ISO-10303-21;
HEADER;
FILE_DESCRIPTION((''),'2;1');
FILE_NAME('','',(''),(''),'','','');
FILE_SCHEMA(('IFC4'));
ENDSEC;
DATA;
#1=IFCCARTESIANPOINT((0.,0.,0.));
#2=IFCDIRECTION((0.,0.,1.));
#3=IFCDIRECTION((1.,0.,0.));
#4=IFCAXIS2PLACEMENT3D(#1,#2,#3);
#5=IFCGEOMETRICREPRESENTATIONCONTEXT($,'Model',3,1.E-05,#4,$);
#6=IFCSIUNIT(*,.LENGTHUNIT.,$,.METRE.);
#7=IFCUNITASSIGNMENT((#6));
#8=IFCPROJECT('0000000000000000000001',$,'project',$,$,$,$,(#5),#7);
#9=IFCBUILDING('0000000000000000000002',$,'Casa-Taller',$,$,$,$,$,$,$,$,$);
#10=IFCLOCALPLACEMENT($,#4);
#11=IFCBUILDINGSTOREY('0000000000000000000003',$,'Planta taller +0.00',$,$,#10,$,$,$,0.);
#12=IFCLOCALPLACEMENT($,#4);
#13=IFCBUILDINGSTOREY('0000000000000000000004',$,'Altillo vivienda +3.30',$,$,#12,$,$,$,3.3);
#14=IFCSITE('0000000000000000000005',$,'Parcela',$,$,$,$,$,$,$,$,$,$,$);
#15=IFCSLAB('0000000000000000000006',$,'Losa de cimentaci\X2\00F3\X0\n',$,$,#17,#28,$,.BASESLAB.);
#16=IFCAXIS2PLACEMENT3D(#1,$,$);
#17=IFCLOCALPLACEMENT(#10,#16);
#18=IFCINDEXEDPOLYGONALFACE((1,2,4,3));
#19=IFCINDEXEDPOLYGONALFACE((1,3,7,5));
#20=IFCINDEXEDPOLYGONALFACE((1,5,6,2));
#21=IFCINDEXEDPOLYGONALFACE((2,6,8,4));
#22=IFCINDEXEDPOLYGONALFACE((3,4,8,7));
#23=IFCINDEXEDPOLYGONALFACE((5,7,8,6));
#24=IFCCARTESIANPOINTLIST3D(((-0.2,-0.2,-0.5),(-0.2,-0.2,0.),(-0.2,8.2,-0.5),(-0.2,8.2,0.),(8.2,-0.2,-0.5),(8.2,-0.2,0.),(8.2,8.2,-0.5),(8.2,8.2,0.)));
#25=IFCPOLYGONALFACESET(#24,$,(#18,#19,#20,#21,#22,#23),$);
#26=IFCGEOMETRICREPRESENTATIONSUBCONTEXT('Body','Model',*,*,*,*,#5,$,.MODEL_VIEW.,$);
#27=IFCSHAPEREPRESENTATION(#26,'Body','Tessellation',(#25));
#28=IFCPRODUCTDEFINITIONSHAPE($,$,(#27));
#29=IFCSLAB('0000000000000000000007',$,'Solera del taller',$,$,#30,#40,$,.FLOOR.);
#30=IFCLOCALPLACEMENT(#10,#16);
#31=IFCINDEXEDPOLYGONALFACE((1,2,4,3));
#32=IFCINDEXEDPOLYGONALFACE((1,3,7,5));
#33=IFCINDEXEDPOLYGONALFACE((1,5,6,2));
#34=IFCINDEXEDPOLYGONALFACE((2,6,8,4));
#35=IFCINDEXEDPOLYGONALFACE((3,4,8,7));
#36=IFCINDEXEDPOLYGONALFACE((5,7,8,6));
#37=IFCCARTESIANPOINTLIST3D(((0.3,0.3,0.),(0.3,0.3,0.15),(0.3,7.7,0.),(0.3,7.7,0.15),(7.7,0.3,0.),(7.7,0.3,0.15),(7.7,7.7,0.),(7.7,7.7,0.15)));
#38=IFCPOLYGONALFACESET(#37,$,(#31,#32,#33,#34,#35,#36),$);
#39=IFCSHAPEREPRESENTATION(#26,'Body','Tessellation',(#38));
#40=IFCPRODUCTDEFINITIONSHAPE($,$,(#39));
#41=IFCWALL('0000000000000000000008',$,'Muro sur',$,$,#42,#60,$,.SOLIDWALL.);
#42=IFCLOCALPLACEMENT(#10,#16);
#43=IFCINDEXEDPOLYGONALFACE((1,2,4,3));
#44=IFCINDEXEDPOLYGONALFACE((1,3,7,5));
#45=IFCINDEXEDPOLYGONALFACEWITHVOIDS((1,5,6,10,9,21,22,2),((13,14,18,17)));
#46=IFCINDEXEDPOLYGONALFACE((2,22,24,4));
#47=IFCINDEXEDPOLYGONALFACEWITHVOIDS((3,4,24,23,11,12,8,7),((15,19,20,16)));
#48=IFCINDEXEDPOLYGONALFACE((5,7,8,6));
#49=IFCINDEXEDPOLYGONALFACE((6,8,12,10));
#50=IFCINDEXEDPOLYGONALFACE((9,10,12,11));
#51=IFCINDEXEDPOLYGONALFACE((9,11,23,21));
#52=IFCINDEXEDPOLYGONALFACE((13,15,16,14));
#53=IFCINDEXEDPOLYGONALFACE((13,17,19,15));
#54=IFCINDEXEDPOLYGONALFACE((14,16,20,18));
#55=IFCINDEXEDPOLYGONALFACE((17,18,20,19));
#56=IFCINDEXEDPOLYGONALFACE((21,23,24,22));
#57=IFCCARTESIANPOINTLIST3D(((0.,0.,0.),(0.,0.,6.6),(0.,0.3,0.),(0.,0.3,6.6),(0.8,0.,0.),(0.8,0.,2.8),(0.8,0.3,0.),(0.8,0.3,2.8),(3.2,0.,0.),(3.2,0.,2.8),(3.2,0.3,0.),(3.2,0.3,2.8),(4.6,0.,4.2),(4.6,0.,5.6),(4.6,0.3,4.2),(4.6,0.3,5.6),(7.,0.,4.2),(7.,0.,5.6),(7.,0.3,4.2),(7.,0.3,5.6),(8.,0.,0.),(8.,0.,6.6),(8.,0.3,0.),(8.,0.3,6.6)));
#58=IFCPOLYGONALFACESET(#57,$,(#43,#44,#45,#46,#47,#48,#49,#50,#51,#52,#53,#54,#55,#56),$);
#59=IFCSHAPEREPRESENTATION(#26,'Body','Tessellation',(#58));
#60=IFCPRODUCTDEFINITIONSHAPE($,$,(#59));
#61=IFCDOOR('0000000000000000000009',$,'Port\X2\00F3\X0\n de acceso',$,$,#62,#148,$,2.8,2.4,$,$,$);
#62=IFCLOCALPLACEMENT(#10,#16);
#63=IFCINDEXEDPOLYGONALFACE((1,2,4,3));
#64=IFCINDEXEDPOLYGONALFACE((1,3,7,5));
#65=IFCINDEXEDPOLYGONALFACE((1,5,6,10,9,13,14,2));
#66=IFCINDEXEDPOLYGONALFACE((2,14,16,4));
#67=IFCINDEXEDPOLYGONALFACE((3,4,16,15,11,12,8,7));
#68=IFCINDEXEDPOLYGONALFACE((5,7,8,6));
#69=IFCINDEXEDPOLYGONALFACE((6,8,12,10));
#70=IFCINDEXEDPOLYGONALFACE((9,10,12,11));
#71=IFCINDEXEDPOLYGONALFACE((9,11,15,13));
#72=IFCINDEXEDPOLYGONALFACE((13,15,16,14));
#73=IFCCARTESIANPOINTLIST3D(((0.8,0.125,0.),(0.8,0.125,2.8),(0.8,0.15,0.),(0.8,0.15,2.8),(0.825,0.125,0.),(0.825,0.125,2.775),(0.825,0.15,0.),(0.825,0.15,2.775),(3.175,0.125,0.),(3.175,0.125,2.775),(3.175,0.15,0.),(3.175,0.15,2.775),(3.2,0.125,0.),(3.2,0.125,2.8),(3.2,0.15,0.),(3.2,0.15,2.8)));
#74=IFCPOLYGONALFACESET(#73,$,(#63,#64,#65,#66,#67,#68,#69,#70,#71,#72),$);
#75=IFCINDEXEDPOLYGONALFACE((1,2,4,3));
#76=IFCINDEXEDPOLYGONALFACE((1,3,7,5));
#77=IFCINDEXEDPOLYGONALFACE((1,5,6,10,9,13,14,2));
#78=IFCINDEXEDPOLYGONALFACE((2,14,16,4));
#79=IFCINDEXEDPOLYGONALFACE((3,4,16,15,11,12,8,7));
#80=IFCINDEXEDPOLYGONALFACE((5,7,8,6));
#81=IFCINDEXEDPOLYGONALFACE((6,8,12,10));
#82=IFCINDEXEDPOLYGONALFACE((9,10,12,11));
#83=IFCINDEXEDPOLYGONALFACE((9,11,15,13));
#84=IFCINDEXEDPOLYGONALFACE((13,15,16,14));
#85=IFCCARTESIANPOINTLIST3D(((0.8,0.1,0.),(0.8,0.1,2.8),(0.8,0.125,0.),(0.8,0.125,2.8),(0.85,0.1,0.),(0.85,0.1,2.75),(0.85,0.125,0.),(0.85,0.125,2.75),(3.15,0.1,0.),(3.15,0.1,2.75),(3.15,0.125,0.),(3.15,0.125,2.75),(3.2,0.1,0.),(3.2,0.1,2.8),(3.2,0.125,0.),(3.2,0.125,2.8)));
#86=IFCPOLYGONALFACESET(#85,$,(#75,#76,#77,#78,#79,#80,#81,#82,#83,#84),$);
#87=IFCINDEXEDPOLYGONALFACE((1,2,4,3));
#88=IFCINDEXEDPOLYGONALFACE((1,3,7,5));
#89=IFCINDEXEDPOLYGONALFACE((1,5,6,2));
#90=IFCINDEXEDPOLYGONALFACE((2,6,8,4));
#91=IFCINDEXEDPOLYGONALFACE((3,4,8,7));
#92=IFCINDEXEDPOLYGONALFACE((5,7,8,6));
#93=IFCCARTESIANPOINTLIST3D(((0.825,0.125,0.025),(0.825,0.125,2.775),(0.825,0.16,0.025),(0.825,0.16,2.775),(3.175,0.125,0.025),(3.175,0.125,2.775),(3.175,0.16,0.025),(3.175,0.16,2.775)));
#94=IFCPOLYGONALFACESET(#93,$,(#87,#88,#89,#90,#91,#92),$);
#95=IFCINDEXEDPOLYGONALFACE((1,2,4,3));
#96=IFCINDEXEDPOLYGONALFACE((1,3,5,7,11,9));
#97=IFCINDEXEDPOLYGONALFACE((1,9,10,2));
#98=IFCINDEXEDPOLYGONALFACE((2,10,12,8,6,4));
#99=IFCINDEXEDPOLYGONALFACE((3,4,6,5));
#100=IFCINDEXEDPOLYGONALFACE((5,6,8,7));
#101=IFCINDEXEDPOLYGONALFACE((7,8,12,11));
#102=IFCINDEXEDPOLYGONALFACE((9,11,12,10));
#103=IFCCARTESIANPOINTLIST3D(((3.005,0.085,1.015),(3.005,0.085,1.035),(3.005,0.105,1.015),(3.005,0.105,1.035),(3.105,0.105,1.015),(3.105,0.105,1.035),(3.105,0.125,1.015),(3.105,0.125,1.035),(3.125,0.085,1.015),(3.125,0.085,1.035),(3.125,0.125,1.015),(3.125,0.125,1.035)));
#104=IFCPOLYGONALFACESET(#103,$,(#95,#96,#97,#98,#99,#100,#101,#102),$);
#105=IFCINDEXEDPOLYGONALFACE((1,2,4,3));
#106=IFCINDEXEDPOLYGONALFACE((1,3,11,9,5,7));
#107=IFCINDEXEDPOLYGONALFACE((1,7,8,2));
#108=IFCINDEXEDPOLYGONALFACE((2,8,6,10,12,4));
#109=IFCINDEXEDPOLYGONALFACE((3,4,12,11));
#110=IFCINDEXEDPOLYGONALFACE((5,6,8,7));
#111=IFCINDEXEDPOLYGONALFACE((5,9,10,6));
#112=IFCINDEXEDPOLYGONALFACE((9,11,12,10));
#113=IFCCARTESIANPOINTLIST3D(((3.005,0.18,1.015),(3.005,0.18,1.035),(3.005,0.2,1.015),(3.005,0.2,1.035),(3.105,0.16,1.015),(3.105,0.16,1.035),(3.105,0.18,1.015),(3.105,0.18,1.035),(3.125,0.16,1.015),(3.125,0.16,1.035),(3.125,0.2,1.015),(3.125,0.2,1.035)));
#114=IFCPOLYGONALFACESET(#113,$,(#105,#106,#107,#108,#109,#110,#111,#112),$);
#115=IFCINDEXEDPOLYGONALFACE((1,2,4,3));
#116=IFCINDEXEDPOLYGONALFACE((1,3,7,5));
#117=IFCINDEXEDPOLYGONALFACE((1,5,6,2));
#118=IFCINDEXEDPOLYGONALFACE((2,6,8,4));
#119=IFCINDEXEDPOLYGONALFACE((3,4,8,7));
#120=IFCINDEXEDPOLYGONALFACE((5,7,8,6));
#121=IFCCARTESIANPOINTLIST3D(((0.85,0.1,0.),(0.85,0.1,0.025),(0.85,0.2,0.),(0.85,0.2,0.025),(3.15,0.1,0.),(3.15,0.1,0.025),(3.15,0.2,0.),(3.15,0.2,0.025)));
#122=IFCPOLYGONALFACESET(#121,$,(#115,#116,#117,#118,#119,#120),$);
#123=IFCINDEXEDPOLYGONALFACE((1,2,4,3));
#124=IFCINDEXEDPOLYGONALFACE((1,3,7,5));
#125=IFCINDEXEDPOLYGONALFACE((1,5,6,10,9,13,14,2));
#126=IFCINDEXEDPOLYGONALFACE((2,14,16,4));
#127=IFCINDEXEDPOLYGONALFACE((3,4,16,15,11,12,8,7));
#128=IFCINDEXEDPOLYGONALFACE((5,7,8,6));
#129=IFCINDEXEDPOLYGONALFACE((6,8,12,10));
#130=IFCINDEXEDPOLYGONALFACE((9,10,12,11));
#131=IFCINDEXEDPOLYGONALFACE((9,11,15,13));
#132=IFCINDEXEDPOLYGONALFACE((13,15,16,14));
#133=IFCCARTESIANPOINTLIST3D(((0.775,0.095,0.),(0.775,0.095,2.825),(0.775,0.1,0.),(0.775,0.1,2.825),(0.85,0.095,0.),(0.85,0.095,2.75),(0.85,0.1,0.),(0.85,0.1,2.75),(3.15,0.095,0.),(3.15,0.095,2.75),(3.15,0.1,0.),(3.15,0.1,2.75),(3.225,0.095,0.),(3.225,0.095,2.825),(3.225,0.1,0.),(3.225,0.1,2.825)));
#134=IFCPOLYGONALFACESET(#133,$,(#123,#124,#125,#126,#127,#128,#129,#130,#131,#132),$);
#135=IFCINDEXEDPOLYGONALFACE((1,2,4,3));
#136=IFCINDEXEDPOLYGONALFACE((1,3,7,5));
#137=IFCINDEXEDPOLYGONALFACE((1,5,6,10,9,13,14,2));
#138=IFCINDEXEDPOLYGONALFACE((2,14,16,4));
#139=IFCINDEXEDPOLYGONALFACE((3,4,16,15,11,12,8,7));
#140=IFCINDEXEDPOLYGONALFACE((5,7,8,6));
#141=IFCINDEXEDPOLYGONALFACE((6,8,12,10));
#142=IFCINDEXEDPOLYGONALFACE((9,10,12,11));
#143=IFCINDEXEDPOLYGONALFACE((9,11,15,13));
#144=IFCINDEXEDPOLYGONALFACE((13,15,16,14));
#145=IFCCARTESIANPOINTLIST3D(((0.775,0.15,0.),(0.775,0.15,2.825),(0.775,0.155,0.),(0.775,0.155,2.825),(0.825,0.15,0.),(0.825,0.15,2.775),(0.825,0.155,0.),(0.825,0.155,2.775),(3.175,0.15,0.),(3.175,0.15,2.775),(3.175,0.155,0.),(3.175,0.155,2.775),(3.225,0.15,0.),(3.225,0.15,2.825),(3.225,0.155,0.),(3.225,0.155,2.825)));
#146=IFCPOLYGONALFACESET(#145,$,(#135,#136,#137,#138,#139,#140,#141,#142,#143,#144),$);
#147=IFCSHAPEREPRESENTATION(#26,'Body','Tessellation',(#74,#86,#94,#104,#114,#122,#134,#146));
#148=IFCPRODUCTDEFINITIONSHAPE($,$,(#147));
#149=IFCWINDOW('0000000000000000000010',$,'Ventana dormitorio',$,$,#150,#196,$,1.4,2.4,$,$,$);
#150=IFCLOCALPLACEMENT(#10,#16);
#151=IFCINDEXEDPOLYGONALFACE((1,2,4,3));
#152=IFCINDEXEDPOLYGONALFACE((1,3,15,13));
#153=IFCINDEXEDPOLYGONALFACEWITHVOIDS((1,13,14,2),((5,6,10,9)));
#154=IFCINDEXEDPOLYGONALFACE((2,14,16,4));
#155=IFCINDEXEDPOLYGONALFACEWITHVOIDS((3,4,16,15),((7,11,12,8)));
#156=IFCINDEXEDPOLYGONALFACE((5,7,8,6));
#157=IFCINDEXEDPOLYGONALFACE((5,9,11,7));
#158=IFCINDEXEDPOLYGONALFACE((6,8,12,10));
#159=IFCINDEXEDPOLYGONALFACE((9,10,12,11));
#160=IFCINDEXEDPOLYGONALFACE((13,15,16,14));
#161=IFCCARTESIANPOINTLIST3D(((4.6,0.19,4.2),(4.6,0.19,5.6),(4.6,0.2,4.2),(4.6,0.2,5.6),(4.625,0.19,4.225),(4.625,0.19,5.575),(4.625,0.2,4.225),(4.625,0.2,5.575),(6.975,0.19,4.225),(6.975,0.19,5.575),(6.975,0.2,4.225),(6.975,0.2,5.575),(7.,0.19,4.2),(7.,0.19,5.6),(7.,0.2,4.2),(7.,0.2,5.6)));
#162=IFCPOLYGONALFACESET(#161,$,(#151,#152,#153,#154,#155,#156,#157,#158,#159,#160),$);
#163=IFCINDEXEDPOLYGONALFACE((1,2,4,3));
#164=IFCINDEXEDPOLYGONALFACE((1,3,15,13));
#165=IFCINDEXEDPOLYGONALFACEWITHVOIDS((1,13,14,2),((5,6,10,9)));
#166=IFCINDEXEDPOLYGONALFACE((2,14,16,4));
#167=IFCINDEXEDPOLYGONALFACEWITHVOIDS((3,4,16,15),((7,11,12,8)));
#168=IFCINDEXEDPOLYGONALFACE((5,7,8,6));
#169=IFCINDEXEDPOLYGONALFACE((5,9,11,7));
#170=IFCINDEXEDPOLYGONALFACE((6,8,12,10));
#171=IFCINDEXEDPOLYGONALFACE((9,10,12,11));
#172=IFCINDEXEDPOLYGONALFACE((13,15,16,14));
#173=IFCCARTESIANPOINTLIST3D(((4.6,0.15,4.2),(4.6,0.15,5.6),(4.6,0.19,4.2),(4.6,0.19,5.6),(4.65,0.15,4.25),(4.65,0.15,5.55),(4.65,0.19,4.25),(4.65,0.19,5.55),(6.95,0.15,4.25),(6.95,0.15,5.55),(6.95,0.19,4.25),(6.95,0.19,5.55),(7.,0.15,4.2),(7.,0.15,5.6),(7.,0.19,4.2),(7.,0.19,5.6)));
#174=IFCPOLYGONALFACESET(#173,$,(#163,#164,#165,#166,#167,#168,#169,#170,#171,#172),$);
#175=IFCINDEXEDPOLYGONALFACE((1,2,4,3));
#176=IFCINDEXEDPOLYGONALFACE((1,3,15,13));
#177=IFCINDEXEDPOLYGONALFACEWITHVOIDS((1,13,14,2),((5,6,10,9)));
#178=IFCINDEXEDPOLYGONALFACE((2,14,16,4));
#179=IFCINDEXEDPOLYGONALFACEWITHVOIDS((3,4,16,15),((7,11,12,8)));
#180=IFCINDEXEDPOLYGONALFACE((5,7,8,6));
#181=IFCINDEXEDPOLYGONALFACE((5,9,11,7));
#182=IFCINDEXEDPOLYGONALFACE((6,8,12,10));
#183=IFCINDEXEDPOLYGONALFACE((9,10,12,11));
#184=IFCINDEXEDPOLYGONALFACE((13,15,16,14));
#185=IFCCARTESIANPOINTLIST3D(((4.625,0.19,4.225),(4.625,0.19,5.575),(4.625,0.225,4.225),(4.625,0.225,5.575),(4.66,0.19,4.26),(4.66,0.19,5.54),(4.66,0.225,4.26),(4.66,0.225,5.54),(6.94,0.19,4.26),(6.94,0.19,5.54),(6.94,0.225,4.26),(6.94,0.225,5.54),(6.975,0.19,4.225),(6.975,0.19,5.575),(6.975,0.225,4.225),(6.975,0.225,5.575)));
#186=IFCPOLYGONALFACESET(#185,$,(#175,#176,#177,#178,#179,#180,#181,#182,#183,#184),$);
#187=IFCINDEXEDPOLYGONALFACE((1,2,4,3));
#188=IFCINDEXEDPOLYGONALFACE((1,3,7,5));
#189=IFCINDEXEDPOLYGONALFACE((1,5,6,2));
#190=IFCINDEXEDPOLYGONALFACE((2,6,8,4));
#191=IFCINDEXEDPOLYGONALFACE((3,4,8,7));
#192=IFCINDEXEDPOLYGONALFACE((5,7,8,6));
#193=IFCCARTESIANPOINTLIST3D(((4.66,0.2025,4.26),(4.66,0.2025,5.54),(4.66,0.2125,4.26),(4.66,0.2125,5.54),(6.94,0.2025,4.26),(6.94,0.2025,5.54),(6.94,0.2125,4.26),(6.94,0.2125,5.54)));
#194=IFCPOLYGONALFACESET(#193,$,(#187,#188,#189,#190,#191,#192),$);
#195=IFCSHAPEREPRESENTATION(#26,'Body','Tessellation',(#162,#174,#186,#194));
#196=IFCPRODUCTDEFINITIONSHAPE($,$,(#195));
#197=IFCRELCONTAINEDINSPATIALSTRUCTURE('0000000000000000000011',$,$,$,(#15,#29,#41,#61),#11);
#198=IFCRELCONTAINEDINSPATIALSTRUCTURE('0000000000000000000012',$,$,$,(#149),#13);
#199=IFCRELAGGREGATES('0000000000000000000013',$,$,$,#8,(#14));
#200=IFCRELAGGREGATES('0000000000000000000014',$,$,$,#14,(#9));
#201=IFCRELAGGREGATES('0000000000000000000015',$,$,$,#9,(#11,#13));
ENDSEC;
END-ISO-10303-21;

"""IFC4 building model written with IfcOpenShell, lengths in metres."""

from ifc_helpers import new_model, si_unit, frame, origin_with_axes, place, context, subcontext, project, spatial, line, indexed_curve, outline, extrude, element, fill, save


model = new_model("IFC4")

# Units and contexts
model_context = context("Model", 3, precision=1e-05, world=origin_with_axes())
body_context = subcontext(model_context, "Body", "Model", "MODEL_VIEW")
ifc_project = project(units=[si_unit("LENGTHUNIT", "METRE")], contexts=[model_context])

# Site, building, storey
site = spatial("IfcSite", under=ifc_project, Name="Parcela")
building = spatial("IfcBuilding", under=site, Name="Casa-Taller")
storey_1_placement = place(None, origin_with_axes())
storey_1 = spatial("IfcBuildingStorey", under=building, at=storey_1_placement, Name="Planta taller +0.00", Elevation=0.0)

# Slabs
slab_1_placement = place(storey_1_placement, frame((-0.2, -0.2, -0.5), z_axis=(0.0, 0.0, 1.0), x_axis=(1.0, 0.0, 0.0)))
element("IfcSlab", 1, at=slab_1_placement, inside=storey_1, Name="Losa de cimentación", PredefinedType="BASESLAB", context=body_context, shape_type="SweptSolid", body=[
    extrude(outline(indexed_curve([(0.0, 0.0), (8.4, 0.0), (8.4, 8.4), (0.0, 8.4)])), None, (0.0, 0.0, 1.0), 0.5),
])
slab_2_placement = place(storey_1_placement, frame((0.3, 0.3, 0.0), z_axis=(0.0, 0.0, 1.0), x_axis=(1.0, 0.0, 0.0)))
element("IfcSlab", 2, at=slab_2_placement, inside=storey_1, Name="Solera del taller", PredefinedType="FLOOR", context=body_context, shape_type="SweptSolid", body=[
    extrude(outline(indexed_curve([(0.0, 0.0), (7.4, 0.0), (7.4, 7.4), (0.0, 7.4)])), None, (0.0, 0.0, 1.0), 0.15),
])

# Wall, openings, door
wall_1_placement = place(storey_1_placement, origin_with_axes())
wall_1 = element("IfcWall", 3, at=wall_1_placement, inside=storey_1, Name="Muro sur", PredefinedType="SOLIDWALL", context=body_context, shape_type="SweptSolid", body=[
    extrude(outline(indexed_curve([(0.0, 0.0), (0.0, 0.3), (8.0, 0.3), (8.0, 0.0), (0.0, 0.0)], self_intersect=False)), origin_with_axes(), (0.0, 0.0, 1.0), 6.6),
])
opening_1_placement = place(wall_1_placement, frame((0.8, -0.1, 0.0), z_axis=(0.0, 0.0, 1.0), x_axis=(1.0, 0.0, 0.0)))
opening_1 = element("IfcOpeningElement", 4, at=opening_1_placement, cuts=wall_1, context=body_context, shape_type="SweptSolid", body=[
    extrude(outline(indexed_curve([(0.0, 0.0), (0.0, 0.5), (2.4, 0.5), (2.4, 0.0), (0.0, 0.0)], self_intersect=False)), origin_with_axes(), (0.0, 0.0, 1.0), 2.8),
])
opening_2_placement = place(wall_1_placement, frame((4.6, -0.1, 4.2), z_axis=(0.0, 0.0, 1.0), x_axis=(1.0, 0.0, 0.0)))
opening_2 = element("IfcOpeningElement", 5, at=opening_2_placement, cuts=wall_1, context=body_context, shape_type="SweptSolid", body=[
    extrude(outline(indexed_curve([(0.0, 0.0), (0.0, 0.5), (2.4, 0.5), (2.4, 0.0), (0.0, 0.0)], self_intersect=False)), origin_with_axes(), (0.0, 0.0, 1.0), 1.4),
])
door_placement = place(opening_1_placement, frame((0.0, 0.2, 0.0), z_axis=(0.0, 0.0, 1.0), x_axis=(1.0, 0.0, 0.0)))
door = element("IfcDoor", 6, at=door_placement, inside=storey_1, Name="Portón de acceso", OverallHeight=2.8, OverallWidth=2.4, context=body_context, shape_type="SweptSolid", body=[
    extrude(outline(indexed_curve([(0.0, 0.0), (0.0, 2.8), (2.4, 2.8), (2.4, 0.0), (2.375, 0.0), (2.375, 2.775), (0.025, 2.775), (0.025, 0.0)], segments=[line(1, 2, 3, 4, 5, 6, 7, 8, 1)])), frame((0.0, 0.025, 0.0), z_axis=(0.0, -1.0, 0.0), x_axis=(1.0, 0.0, 0.0)), (0.0, 0.0, -1.0), 0.025),
    extrude(outline(indexed_curve([(0.0, 0.0), (0.0, 2.8), (2.4, 2.8), (2.4, 0.0), (2.35, 0.0), (2.35, 2.75), (0.05, 2.75), (0.05, 0.0)], segments=[line(1, 2, 3, 4, 5, 6, 7, 8, 1)])), frame((0.0, 0.0, 0.0), z_axis=(0.0, -1.0, 0.0), x_axis=(1.0, 0.0, 0.0)), (0.0, 0.0, -1.0), 0.025),
    extrude(outline(indexed_curve([(0.0, 0.0), (2.35, 0.0), (2.35, 0.035), (0.0, 0.035)], segments=[line(1, 2, 3, 4, 1)])), frame((0.025, 0.025, 0.025), z_axis=(0.0, 0.0, 1.0), x_axis=(1.0, 0.0, 0.0)), (0.0, 0.0, 1.0), 2.75),
    extrude(outline(indexed_curve([(0.0, 0.0), (0.0, -0.04), (-0.12, -0.04), (-0.12, -0.02), (-0.02, -0.02), (-0.02, 0.0)], segments=[line(1, 2, 3, 4, 5, 6, 1)])), frame((2.325, 0.025, 1.015), z_axis=(0.0, 0.0, 1.0), x_axis=(1.0, 0.0, 0.0)), (0.0, 0.0, 1.0), 0.02),
    extrude(outline(indexed_curve([(0.0, 0.0), (0.0, 0.04), (-0.12, 0.04), (-0.12, 0.02), (-0.02, 0.02), (-0.02, 0.0)], segments=[line(1, 2, 3, 4, 5, 6, 1)])), frame((2.325, 0.06, 1.015), z_axis=(0.0, 0.0, 1.0), x_axis=(1.0, 0.0, 0.0)), (0.0, 0.0, 1.0), 0.02),
    extrude(outline(indexed_curve([(0.0, 0.0), (2.3, 0.0), (2.3, 0.1), (0.0, 0.1)], segments=[line(1, 2, 3, 4, 1)])), frame((0.05, 0.0, 0.0), z_axis=(0.0, 0.0, 1.0), x_axis=(1.0, 0.0, 0.0)), (0.0, 0.0, 1.0), 0.025),
    extrude(outline(indexed_curve([(0.0, 0.0), (0.0, 2.825), (2.45, 2.825), (2.45, 0.0), (2.375, 0.0), (2.375, 2.75), (0.075, 2.75), (0.075, 0.0)], segments=[line(1, 2, 3, 4, 5, 6, 7, 8, 1)])), frame((-0.025, -0.005, 0.0), z_axis=(0.0, -1.0, 0.0), x_axis=(1.0, 0.0, 0.0)), (0.0, 0.0, -1.0), 0.005),
    extrude(outline(indexed_curve([(0.0, 0.0), (0.0, 2.825), (2.45, 2.825), (2.45, 0.0), (2.4, 0.0), (2.4, 2.775), (0.05, 2.775), (0.05, 0.0)], segments=[line(1, 2, 3, 4, 5, 6, 7, 8, 1)])), frame((-0.025, 0.05, 0.0), z_axis=(0.0, -1.0, 0.0), x_axis=(1.0, 0.0, 0.0)), (0.0, 0.0, -1.0), 0.005),
])
fill(opening_1, door)

# Shared definitions
storey_2_placement = place(None, origin_with_axes())
storey_2 = spatial("IfcBuildingStorey", under=building, at=storey_2_placement, Name="Altillo vivienda +3.30", Elevation=3.3)

# Window
window_1_placement = place(opening_2_placement, frame((0.0, 0.2, 0.0), z_axis=(0.0, 0.0, 1.0), x_axis=(1.0, 0.0, 0.0)))
window_1 = element("IfcWindow", 7, at=window_1_placement, inside=storey_2, Name="Ventana dormitorio", OverallHeight=1.4, OverallWidth=2.4, context=body_context, shape_type="SweptSolid", body=[
    extrude(outline(indexed_curve([(0.0, 0.0), (2.4, 0.0), (2.4, 1.4), (0.0, 1.4)], segments=[line(1, 2, 3, 4, 1)]), holes=[indexed_curve([(0.025, 0.025), (2.375, 0.025), (2.375, 1.375), (0.025, 1.375)], segments=[line(1, 2, 3, 4, 1)])]), frame((0.0, 0.09, 0.0), z_axis=(0.0, -1.0, 0.0), x_axis=(1.0, 0.0, 0.0)), (0.0, 0.0, -1.0), 0.01),
    extrude(outline(indexed_curve([(0.0, 0.0), (2.4, 0.0), (2.4, 1.4), (0.0, 1.4)], segments=[line(1, 2, 3, 4, 1)]), holes=[indexed_curve([(0.05, 0.05), (2.35, 0.05), (2.35, 1.35), (0.05, 1.35)], segments=[line(1, 2, 3, 4, 1)])]), frame((0.0, 0.05, 0.0), z_axis=(0.0, -1.0, 0.0), x_axis=(1.0, 0.0, 0.0)), (0.0, 0.0, -1.0), 0.04),
    extrude(outline(indexed_curve([(0.0, 0.0), (2.35, 0.0), (2.35, 1.35), (0.0, 1.35)], segments=[line(1, 2, 3, 4, 1)]), holes=[indexed_curve([(0.035, 0.035), (2.315, 0.035), (2.315, 1.315), (0.035, 1.315)], segments=[line(1, 2, 3, 4, 1)])]), frame((0.025, 0.09, 0.025), z_axis=(0.0, -1.0, 0.0), x_axis=(1.0, 0.0, 0.0)), (0.0, 0.0, -1.0), 0.035),
    extrude(outline(indexed_curve([(0.035, 0.035), (2.315, 0.035), (2.315, 1.315), (0.035, 1.315)], segments=[line(1, 2, 3, 4, 1)])), frame((0.025, 0.1025, 0.025), z_axis=(0.0, -1.0, 0.0), x_axis=(1.0, 0.0, 0.0)), (0.0, 0.0, -1.0), 0.01),
])
fill(opening_2, window_1)

save(model, "model.ifc")
